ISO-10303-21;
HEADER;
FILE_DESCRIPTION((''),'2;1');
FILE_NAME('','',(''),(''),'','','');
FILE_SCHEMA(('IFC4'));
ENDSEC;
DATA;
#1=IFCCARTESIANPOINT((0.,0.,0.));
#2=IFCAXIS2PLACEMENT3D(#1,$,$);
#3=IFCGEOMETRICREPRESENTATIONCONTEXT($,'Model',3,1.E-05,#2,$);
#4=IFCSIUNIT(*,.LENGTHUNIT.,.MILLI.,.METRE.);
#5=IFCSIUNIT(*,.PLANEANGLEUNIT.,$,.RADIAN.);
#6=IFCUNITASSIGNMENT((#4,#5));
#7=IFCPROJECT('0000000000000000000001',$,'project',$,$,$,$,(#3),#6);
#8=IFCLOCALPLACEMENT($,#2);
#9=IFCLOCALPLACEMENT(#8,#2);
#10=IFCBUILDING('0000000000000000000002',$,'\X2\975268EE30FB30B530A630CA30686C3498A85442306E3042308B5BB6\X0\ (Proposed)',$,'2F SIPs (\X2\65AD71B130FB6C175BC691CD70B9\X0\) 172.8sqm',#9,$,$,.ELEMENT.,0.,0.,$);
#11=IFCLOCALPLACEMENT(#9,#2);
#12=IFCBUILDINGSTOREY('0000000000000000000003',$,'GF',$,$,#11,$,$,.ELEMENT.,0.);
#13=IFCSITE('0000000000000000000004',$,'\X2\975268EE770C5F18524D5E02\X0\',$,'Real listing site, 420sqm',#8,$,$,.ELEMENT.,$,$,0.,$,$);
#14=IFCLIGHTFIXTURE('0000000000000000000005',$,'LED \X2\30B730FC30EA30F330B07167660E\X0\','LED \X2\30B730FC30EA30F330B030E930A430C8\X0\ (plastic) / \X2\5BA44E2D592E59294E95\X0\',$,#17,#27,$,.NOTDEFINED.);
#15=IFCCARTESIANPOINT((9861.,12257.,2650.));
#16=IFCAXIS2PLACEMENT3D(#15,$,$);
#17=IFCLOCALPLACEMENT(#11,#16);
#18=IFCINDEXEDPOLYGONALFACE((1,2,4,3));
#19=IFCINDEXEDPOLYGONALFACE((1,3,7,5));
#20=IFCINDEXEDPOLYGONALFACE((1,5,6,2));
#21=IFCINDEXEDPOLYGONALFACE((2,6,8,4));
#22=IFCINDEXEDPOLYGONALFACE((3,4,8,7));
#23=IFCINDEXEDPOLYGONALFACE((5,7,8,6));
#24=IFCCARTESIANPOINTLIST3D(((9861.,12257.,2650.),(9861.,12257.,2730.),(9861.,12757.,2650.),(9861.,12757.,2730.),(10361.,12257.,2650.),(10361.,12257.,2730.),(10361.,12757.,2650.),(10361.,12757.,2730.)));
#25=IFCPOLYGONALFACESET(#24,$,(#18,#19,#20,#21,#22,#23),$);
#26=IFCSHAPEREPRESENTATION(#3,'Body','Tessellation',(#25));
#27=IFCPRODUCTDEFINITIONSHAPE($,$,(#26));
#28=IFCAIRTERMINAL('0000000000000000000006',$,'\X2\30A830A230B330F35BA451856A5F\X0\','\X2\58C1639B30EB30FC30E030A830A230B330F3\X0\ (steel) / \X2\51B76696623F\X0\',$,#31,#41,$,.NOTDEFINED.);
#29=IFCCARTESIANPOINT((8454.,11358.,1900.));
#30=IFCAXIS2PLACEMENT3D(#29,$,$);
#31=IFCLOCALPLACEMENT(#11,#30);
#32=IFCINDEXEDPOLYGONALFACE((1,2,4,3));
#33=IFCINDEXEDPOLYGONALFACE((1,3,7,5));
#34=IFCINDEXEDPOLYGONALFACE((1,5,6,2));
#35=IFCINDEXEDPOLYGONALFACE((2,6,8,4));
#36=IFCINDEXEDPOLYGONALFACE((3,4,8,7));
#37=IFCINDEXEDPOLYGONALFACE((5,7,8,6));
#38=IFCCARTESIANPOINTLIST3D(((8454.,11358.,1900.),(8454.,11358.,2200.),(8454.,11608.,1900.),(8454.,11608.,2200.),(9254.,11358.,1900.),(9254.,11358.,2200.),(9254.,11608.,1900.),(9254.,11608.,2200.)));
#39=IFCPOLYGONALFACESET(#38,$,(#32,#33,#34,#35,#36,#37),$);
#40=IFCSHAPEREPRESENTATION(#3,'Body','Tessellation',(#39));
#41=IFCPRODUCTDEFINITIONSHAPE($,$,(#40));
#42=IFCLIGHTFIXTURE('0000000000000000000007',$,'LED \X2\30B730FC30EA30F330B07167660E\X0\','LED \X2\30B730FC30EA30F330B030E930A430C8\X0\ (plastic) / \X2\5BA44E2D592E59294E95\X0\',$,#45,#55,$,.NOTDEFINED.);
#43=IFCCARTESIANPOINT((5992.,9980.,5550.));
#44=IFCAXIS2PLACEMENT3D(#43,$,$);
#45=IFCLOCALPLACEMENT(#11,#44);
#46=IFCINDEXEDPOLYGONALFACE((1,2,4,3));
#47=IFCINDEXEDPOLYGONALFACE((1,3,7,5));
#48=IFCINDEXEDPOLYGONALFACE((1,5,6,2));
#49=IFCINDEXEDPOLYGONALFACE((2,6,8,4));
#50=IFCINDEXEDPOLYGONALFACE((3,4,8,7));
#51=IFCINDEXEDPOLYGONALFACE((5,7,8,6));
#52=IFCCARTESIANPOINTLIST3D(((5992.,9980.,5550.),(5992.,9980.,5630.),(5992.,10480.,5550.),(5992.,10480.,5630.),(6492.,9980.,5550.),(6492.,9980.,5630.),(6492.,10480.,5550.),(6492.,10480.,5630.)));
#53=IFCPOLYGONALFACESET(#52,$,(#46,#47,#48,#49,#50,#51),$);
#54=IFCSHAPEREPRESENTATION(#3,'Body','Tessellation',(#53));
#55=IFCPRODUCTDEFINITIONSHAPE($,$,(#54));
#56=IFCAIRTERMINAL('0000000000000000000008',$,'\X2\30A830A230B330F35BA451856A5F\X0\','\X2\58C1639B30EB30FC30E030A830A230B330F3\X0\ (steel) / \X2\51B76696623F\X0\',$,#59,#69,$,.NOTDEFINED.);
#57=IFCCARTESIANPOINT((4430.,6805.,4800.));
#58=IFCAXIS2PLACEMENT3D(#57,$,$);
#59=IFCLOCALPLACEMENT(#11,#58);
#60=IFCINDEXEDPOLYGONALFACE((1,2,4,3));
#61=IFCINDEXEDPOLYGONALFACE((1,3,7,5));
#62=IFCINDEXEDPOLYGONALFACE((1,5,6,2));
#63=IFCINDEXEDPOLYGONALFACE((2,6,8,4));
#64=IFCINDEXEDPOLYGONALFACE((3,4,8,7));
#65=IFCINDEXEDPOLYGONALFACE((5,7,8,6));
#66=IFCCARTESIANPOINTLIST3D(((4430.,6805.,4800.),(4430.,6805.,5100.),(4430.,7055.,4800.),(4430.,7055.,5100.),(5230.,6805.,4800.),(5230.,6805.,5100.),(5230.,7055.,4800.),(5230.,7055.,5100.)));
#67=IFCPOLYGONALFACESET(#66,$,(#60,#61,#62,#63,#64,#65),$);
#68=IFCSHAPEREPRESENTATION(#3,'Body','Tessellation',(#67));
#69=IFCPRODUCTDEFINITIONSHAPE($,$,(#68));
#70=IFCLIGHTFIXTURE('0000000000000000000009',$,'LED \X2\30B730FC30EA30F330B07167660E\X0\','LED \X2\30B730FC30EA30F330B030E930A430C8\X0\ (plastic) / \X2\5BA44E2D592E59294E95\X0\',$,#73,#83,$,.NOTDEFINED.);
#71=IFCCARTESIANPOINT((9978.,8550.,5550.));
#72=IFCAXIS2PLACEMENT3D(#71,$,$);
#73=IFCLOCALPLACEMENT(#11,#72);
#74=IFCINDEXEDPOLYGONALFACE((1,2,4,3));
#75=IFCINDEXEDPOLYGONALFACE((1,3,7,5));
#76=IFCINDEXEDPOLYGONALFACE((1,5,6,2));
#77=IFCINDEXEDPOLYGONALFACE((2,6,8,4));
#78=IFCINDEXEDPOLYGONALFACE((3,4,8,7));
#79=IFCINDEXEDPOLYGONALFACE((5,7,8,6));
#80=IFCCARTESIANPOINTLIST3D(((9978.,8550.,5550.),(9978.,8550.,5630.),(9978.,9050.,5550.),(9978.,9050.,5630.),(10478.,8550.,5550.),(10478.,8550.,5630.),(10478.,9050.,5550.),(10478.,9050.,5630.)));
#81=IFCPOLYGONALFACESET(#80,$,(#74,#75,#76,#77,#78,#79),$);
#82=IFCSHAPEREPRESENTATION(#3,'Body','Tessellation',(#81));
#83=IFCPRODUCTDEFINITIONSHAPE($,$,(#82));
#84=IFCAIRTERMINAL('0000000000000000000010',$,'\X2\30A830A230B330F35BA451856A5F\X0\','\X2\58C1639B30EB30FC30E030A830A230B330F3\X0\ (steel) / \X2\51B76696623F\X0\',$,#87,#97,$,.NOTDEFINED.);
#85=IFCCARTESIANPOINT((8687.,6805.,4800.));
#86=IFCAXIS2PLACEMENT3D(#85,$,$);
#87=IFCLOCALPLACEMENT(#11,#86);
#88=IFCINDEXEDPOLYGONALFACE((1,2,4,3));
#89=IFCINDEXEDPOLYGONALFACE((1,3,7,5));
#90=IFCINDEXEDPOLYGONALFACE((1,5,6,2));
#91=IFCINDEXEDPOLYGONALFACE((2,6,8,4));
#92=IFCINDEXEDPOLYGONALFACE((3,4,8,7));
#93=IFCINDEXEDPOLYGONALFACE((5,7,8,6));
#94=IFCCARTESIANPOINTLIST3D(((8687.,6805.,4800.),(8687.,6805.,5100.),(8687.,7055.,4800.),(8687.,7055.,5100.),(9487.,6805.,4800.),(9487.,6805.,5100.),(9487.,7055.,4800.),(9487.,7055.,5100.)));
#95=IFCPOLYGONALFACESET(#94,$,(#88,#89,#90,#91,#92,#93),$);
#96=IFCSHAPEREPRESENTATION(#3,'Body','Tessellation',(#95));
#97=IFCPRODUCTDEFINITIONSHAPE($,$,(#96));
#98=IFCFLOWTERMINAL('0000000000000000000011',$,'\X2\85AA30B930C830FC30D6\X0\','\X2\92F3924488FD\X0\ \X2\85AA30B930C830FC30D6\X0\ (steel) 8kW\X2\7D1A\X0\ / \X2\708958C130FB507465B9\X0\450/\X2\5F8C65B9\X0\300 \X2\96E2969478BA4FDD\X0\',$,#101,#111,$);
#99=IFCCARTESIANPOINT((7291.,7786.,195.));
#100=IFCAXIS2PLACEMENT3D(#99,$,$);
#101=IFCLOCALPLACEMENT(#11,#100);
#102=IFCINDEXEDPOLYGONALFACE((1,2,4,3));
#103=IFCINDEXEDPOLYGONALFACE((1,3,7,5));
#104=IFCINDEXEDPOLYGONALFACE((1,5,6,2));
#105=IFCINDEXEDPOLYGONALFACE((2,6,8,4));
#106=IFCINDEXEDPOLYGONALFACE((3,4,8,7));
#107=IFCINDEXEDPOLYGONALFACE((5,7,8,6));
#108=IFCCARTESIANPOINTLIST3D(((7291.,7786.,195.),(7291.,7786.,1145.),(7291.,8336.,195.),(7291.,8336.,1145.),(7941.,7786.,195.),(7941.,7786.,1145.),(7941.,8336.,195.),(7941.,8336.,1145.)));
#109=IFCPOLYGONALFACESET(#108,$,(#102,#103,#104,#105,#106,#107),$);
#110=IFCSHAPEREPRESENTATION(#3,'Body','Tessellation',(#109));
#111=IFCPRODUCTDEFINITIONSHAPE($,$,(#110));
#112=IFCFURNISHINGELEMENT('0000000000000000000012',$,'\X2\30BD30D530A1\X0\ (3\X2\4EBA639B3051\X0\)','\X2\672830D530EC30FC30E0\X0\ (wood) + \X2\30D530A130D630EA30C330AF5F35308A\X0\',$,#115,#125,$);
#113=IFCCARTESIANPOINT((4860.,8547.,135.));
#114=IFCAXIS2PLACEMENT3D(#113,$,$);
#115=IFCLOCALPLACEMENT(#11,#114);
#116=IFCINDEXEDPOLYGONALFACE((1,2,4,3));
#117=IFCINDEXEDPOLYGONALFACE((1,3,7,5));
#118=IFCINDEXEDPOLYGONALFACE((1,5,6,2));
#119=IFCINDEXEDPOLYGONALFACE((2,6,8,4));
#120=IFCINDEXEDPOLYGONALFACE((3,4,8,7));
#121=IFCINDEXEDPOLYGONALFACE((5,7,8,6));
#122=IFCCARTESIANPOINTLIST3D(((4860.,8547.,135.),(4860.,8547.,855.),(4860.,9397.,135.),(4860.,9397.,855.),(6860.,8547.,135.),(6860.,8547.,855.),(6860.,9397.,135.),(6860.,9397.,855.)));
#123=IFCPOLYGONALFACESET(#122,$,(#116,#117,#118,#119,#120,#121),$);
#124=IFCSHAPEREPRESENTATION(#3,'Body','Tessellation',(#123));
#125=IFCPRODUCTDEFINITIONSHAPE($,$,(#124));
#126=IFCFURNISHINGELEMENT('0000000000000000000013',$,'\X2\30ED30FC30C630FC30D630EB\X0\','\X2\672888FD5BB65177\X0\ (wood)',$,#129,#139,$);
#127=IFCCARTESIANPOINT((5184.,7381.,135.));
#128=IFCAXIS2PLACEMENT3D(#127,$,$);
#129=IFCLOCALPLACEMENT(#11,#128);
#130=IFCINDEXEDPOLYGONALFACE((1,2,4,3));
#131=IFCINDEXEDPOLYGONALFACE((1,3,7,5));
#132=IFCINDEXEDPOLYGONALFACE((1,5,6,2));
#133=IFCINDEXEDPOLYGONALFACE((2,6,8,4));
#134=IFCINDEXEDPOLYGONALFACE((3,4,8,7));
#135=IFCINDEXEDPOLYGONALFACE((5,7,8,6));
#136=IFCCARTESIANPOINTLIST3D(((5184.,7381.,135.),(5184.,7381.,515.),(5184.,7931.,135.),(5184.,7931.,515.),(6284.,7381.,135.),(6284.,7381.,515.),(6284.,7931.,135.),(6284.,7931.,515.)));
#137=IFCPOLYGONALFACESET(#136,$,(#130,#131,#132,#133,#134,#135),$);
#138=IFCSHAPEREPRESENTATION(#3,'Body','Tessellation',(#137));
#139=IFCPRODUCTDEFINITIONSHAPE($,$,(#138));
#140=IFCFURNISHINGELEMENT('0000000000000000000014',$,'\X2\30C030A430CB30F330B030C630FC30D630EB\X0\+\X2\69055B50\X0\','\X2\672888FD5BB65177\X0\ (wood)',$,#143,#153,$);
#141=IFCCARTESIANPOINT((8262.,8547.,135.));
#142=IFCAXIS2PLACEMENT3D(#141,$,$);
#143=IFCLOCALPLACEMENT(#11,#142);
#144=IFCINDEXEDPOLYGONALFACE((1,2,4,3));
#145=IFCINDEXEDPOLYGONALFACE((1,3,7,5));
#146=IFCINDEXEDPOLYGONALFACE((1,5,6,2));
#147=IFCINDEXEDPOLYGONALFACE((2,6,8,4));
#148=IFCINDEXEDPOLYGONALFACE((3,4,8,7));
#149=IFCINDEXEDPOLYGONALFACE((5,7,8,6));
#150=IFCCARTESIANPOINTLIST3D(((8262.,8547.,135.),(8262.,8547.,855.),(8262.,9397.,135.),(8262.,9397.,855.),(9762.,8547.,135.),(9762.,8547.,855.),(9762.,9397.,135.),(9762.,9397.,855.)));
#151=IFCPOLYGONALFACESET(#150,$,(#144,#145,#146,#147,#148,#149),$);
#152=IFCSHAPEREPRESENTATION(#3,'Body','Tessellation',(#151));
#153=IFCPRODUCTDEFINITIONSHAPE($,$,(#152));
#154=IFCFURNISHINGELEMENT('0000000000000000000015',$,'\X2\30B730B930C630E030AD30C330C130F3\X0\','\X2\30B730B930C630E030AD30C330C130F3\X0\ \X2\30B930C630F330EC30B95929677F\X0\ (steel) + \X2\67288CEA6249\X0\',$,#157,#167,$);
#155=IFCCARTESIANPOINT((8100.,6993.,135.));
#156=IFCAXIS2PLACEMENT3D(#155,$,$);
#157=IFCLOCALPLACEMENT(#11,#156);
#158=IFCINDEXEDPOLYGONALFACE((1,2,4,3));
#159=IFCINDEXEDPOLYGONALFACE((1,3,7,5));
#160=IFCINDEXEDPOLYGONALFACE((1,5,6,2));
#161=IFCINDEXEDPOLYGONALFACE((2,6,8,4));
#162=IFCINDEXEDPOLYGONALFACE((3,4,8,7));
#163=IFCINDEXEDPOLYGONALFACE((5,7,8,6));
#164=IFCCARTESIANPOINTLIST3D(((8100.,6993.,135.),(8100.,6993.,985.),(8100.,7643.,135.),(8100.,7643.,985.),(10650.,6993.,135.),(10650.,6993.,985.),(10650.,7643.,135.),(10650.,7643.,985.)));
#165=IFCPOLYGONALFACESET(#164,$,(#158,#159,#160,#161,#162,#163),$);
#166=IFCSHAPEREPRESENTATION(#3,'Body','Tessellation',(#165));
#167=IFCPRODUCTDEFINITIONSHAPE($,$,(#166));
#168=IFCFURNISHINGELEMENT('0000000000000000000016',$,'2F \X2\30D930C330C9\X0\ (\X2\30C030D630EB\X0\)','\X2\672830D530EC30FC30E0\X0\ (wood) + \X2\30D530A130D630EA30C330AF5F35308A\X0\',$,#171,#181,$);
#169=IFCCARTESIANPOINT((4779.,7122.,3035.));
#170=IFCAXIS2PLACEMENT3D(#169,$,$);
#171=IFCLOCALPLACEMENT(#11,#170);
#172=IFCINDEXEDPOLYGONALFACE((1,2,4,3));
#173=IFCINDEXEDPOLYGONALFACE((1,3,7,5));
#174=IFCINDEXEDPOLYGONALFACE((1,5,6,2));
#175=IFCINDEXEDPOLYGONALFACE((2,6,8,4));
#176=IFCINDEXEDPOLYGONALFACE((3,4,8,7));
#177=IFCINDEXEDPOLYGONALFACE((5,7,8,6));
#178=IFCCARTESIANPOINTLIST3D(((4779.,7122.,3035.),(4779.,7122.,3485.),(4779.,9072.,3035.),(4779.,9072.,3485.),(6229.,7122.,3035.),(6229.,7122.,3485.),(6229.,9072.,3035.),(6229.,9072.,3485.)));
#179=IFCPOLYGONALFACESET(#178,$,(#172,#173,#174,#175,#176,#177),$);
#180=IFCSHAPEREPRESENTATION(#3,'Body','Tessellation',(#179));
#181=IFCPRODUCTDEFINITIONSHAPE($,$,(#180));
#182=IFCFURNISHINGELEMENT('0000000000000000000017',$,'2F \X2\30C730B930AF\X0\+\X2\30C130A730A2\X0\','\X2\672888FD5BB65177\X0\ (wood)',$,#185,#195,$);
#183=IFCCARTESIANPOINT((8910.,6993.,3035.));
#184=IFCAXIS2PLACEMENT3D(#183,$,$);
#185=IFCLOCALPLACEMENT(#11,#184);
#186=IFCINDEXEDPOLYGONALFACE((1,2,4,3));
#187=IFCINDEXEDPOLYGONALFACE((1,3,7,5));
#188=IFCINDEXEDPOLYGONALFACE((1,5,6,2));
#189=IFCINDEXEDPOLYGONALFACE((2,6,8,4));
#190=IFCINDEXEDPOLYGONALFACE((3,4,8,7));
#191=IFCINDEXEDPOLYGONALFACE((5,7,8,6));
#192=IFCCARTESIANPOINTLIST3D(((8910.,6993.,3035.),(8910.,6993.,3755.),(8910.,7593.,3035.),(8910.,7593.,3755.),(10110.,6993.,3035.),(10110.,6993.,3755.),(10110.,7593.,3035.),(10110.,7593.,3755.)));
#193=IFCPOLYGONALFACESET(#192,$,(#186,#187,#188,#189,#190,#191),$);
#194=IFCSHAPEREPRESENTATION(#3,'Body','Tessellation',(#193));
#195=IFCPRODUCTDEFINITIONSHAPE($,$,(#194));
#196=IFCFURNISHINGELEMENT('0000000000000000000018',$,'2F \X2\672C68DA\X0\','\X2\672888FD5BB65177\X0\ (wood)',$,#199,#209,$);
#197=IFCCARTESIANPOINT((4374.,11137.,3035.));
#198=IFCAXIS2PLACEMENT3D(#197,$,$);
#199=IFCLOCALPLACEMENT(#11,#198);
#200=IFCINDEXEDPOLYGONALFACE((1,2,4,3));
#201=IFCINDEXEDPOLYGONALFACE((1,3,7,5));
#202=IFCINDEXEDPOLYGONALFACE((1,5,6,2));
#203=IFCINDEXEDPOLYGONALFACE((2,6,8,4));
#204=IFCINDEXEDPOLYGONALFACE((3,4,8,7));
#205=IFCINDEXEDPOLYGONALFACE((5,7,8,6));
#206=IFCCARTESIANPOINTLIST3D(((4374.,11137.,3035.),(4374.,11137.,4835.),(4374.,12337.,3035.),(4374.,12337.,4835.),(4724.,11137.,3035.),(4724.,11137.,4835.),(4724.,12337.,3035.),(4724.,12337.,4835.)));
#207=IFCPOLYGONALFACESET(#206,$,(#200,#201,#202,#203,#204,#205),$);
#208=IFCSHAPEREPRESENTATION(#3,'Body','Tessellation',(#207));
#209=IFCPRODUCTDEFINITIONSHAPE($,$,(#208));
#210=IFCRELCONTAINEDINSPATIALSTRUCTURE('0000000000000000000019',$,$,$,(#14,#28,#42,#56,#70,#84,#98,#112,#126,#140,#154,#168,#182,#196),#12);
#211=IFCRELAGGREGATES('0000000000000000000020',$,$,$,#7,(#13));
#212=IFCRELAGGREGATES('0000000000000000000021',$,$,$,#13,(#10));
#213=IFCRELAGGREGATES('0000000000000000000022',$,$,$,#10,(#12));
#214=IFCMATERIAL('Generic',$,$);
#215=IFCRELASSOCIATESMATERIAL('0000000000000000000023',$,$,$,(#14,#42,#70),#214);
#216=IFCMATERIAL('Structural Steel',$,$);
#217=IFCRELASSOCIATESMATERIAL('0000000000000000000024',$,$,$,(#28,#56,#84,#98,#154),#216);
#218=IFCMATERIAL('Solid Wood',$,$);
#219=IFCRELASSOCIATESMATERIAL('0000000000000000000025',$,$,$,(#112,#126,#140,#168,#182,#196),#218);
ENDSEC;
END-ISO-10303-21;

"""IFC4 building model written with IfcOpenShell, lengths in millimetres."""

from ifc_helpers import new_model, si_unit, frame, frame_2d, origin, place, context, project, spatial, rectangle, extrude, material, element, save


model = new_model("IFC4")

# Units and contexts
model_context = context("Model", 3, precision=1e-05, world=origin())
ifc_project = project(units=[si_unit("LENGTHUNIT", "METRE", prefix="MILLI"), si_unit("PLANEANGLEUNIT", "RADIAN")], contexts=[model_context])

# Site, building, storey
site_placement = place(None, origin())
site = spatial("IfcSite", under=ifc_project, at=site_placement, Name="青森県弘前市", ObjectType="Real listing site, 420sqm", CompositionType="ELEMENT", RefElevation=0.0)
building_placement = place(site_placement, origin())
building = spatial("IfcBuilding", under=site, at=building_placement, Name="青森・サウナと水風呂のある家 (Proposed)", ObjectType="2F SIPs (断熱・気密重点) 172.8sqm", CompositionType="ELEMENT", ElevationOfRefHeight=0.0, ElevationOfTerrain=0.0)
storey_placement = place(building_placement, origin())
storey = spatial("IfcBuildingStorey", under=building, at=storey_placement, Name="GF", CompositionType="ELEMENT", Elevation=0.0)

# Shared definitions
ifc_material_1 = material(Name="Solid Wood")

# Shared definitions
ifc_material_2 = material(Name="Structural Steel")

# Shared definitions
ifc_material_3 = material(Name="Generic")

# Light fixture
light_fixture_1_placement = place(storey_placement, frame((9861.0, 12257.0, 2650.0)))
element("IfcLightFixture", 1, at=light_fixture_1_placement, inside=storey, material=ifc_material_3, Name="LED シーリング照明", Description="LED シーリングライト (plastic) / 室中央天井", PredefinedType="NOTDEFINED", context=model_context, shape_type="SweptSolid", body=[
    extrude(rectangle(XDim=500.0, YDim=500.0, at=frame_2d((250.0, 250.0))), frame((9861.0, 12257.0, 2650.0)), (0.0, 0.0, 1.0), 80.0),
])

# Air terminal
air_terminal_1_placement = place(storey_placement, frame((8454.0, 11358.0, 1900.0)))
element("IfcAirTerminal", 2, at=air_terminal_1_placement, inside=storey, material=ifc_material_2, Name="エアコン室内機", Description="壁掛ルームエアコン (steel) / 冷暖房", PredefinedType="NOTDEFINED", context=model_context, shape_type="SweptSolid", body=[
    extrude(rectangle(XDim=800.0, YDim=250.0, at=frame_2d((400.0, 125.0))), frame((8454.0, 11358.0, 1900.0)), (0.0, 0.0, 1.0), 300.0),
])

# Light fixture
light_fixture_2_placement = place(storey_placement, frame((5992.0, 9980.0, 5550.0)))
element("IfcLightFixture", 3, at=light_fixture_2_placement, inside=storey, material=ifc_material_3, Name="LED シーリング照明", Description="LED シーリングライト (plastic) / 室中央天井", PredefinedType="NOTDEFINED", context=model_context, shape_type="SweptSolid", body=[
    extrude(rectangle(XDim=500.0, YDim=500.0, at=frame_2d((250.0, 250.0))), frame((5992.0, 9980.0, 5550.0)), (0.0, 0.0, 1.0), 80.0),
])

# Air terminal
air_terminal_2_placement = place(storey_placement, frame((4430.0, 6805.0, 4800.0)))
element("IfcAirTerminal", 4, at=air_terminal_2_placement, inside=storey, material=ifc_material_2, Name="エアコン室内機", Description="壁掛ルームエアコン (steel) / 冷暖房", PredefinedType="NOTDEFINED", context=model_context, shape_type="SweptSolid", body=[
    extrude(rectangle(XDim=800.0, YDim=250.0, at=frame_2d((400.0, 125.0))), frame((4430.0, 6805.0, 4800.0)), (0.0, 0.0, 1.0), 300.0),
])

# Light fixture
light_fixture_3_placement = place(storey_placement, frame((9978.0, 8550.0, 5550.0)))
element("IfcLightFixture", 5, at=light_fixture_3_placement, inside=storey, material=ifc_material_3, Name="LED シーリング照明", Description="LED シーリングライト (plastic) / 室中央天井", PredefinedType="NOTDEFINED", context=model_context, shape_type="SweptSolid", body=[
    extrude(rectangle(XDim=500.0, YDim=500.0, at=frame_2d((250.0, 250.0))), frame((9978.0, 8550.0, 5550.0)), (0.0, 0.0, 1.0), 80.0),
])

# Air terminal
air_terminal_3_placement = place(storey_placement, frame((8687.0, 6805.0, 4800.0)))
element("IfcAirTerminal", 6, at=air_terminal_3_placement, inside=storey, material=ifc_material_2, Name="エアコン室内機", Description="壁掛ルームエアコン (steel) / 冷暖房", PredefinedType="NOTDEFINED", context=model_context, shape_type="SweptSolid", body=[
    extrude(rectangle(XDim=800.0, YDim=250.0, at=frame_2d((400.0, 125.0))), frame((8687.0, 6805.0, 4800.0)), (0.0, 0.0, 1.0), 300.0),
])

# Flow terminal
flow_terminal_1_placement = place(storey_placement, frame((7291.0, 7786.0, 195.0)))
element("IfcFlowTerminal", 7, at=flow_terminal_1_placement, inside=storey, material=ifc_material_2, Name="薪ストーブ", Description="鋳鉄製 薪ストーブ (steel) 8kW級 / 炉壁・側方450/後方300 離隔確保", context=model_context, shape_type="SweptSolid", body=[
    extrude(rectangle(XDim=650.0, YDim=550.0, at=frame_2d((325.0, 275.0))), frame((7291.0, 7786.0, 195.0)), (0.0, 0.0, 1.0), 950.0),
])

# Furnishing elements
furnishing_1_placement = place(storey_placement, frame((4860.0, 8547.0, 135.0)))
element("IfcFurnishingElement", 8, at=furnishing_1_placement, inside=storey, material=ifc_material_1, Name="ソファ (3人掛け)", Description="木フレーム (wood) + ファブリック張り", context=model_context, shape_type="SweptSolid", body=[
    extrude(rectangle(XDim=2000.0, YDim=850.0, at=frame_2d((1000.0, 425.0))), frame((4860.0, 8547.0, 135.0)), (0.0, 0.0, 1.0), 720.0),
])
furnishing_2_placement = place(storey_placement, frame((5184.0, 7381.0, 135.0)))
element("IfcFurnishingElement", 9, at=furnishing_2_placement, inside=storey, material=ifc_material_1, Name="ローテーブル", Description="木製家具 (wood)", context=model_context, shape_type="SweptSolid", body=[
    extrude(rectangle(XDim=1100.0, YDim=550.0, at=frame_2d((550.0, 275.0))), frame((5184.0, 7381.0, 135.0)), (0.0, 0.0, 1.0), 380.0),
])
furnishing_3_placement = place(storey_placement, frame((8262.0, 8547.0, 135.0)))
element("IfcFurnishingElement", 10, at=furnishing_3_placement, inside=storey, material=ifc_material_1, Name="ダイニングテーブル+椅子", Description="木製家具 (wood)", context=model_context, shape_type="SweptSolid", body=[
    extrude(rectangle(XDim=1500.0, YDim=850.0, at=frame_2d((750.0, 425.0))), frame((8262.0, 8547.0, 135.0)), (0.0, 0.0, 1.0), 720.0),
])
furnishing_4_placement = place(storey_placement, frame((8100.0, 6993.0, 135.0)))
element("IfcFurnishingElement", 11, at=furnishing_4_placement, inside=storey, material=ifc_material_2, Name="システムキッチン", Description="システムキッチン ステンレス天板 (steel) + 木質扉", context=model_context, shape_type="SweptSolid", body=[
    extrude(rectangle(XDim=2550.0, YDim=650.0, at=frame_2d((1275.0, 325.0))), frame((8100.0, 6993.0, 135.0)), (0.0, 0.0, 1.0), 850.0),
])
furnishing_5_placement = place(storey_placement, frame((4779.0, 7122.0, 3035.0)))
element("IfcFurnishingElement", 12, at=furnishing_5_placement, inside=storey, material=ifc_material_1, Name="2F ベッド (ダブル)", Description="木フレーム (wood) + ファブリック張り", context=model_context, shape_type="SweptSolid", body=[
    extrude(rectangle(XDim=1450.0, YDim=1950.0, at=frame_2d((725.0, 975.0))), frame((4779.0, 7122.0, 3035.0)), (0.0, 0.0, 1.0), 450.0),
])
furnishing_6_placement = place(storey_placement, frame((8910.0, 6993.0, 3035.0)))
element("IfcFurnishingElement", 13, at=furnishing_6_placement, inside=storey, material=ifc_material_1, Name="2F デスク+チェア", Description="木製家具 (wood)", context=model_context, shape_type="SweptSolid", body=[
    extrude(rectangle(XDim=1200.0, YDim=600.0, at=frame_2d((600.0, 300.0))), frame((8910.0, 6993.0, 3035.0)), (0.0, 0.0, 1.0), 720.0),
])
furnishing_7_placement = place(storey_placement, frame((4374.0, 11137.0, 3035.0)))
element("IfcFurnishingElement", 14, at=furnishing_7_placement, inside=storey, material=ifc_material_1, Name="2F 本棚", Description="木製家具 (wood)", context=model_context, shape_type="SweptSolid", body=[
    extrude(rectangle(XDim=350.0, YDim=1200.0, at=frame_2d((175.0, 600.0))), frame((4374.0, 11137.0, 3035.0)), (0.0, 0.0, 1.0), 1800.0),
])

save(model, "model.ifc")
